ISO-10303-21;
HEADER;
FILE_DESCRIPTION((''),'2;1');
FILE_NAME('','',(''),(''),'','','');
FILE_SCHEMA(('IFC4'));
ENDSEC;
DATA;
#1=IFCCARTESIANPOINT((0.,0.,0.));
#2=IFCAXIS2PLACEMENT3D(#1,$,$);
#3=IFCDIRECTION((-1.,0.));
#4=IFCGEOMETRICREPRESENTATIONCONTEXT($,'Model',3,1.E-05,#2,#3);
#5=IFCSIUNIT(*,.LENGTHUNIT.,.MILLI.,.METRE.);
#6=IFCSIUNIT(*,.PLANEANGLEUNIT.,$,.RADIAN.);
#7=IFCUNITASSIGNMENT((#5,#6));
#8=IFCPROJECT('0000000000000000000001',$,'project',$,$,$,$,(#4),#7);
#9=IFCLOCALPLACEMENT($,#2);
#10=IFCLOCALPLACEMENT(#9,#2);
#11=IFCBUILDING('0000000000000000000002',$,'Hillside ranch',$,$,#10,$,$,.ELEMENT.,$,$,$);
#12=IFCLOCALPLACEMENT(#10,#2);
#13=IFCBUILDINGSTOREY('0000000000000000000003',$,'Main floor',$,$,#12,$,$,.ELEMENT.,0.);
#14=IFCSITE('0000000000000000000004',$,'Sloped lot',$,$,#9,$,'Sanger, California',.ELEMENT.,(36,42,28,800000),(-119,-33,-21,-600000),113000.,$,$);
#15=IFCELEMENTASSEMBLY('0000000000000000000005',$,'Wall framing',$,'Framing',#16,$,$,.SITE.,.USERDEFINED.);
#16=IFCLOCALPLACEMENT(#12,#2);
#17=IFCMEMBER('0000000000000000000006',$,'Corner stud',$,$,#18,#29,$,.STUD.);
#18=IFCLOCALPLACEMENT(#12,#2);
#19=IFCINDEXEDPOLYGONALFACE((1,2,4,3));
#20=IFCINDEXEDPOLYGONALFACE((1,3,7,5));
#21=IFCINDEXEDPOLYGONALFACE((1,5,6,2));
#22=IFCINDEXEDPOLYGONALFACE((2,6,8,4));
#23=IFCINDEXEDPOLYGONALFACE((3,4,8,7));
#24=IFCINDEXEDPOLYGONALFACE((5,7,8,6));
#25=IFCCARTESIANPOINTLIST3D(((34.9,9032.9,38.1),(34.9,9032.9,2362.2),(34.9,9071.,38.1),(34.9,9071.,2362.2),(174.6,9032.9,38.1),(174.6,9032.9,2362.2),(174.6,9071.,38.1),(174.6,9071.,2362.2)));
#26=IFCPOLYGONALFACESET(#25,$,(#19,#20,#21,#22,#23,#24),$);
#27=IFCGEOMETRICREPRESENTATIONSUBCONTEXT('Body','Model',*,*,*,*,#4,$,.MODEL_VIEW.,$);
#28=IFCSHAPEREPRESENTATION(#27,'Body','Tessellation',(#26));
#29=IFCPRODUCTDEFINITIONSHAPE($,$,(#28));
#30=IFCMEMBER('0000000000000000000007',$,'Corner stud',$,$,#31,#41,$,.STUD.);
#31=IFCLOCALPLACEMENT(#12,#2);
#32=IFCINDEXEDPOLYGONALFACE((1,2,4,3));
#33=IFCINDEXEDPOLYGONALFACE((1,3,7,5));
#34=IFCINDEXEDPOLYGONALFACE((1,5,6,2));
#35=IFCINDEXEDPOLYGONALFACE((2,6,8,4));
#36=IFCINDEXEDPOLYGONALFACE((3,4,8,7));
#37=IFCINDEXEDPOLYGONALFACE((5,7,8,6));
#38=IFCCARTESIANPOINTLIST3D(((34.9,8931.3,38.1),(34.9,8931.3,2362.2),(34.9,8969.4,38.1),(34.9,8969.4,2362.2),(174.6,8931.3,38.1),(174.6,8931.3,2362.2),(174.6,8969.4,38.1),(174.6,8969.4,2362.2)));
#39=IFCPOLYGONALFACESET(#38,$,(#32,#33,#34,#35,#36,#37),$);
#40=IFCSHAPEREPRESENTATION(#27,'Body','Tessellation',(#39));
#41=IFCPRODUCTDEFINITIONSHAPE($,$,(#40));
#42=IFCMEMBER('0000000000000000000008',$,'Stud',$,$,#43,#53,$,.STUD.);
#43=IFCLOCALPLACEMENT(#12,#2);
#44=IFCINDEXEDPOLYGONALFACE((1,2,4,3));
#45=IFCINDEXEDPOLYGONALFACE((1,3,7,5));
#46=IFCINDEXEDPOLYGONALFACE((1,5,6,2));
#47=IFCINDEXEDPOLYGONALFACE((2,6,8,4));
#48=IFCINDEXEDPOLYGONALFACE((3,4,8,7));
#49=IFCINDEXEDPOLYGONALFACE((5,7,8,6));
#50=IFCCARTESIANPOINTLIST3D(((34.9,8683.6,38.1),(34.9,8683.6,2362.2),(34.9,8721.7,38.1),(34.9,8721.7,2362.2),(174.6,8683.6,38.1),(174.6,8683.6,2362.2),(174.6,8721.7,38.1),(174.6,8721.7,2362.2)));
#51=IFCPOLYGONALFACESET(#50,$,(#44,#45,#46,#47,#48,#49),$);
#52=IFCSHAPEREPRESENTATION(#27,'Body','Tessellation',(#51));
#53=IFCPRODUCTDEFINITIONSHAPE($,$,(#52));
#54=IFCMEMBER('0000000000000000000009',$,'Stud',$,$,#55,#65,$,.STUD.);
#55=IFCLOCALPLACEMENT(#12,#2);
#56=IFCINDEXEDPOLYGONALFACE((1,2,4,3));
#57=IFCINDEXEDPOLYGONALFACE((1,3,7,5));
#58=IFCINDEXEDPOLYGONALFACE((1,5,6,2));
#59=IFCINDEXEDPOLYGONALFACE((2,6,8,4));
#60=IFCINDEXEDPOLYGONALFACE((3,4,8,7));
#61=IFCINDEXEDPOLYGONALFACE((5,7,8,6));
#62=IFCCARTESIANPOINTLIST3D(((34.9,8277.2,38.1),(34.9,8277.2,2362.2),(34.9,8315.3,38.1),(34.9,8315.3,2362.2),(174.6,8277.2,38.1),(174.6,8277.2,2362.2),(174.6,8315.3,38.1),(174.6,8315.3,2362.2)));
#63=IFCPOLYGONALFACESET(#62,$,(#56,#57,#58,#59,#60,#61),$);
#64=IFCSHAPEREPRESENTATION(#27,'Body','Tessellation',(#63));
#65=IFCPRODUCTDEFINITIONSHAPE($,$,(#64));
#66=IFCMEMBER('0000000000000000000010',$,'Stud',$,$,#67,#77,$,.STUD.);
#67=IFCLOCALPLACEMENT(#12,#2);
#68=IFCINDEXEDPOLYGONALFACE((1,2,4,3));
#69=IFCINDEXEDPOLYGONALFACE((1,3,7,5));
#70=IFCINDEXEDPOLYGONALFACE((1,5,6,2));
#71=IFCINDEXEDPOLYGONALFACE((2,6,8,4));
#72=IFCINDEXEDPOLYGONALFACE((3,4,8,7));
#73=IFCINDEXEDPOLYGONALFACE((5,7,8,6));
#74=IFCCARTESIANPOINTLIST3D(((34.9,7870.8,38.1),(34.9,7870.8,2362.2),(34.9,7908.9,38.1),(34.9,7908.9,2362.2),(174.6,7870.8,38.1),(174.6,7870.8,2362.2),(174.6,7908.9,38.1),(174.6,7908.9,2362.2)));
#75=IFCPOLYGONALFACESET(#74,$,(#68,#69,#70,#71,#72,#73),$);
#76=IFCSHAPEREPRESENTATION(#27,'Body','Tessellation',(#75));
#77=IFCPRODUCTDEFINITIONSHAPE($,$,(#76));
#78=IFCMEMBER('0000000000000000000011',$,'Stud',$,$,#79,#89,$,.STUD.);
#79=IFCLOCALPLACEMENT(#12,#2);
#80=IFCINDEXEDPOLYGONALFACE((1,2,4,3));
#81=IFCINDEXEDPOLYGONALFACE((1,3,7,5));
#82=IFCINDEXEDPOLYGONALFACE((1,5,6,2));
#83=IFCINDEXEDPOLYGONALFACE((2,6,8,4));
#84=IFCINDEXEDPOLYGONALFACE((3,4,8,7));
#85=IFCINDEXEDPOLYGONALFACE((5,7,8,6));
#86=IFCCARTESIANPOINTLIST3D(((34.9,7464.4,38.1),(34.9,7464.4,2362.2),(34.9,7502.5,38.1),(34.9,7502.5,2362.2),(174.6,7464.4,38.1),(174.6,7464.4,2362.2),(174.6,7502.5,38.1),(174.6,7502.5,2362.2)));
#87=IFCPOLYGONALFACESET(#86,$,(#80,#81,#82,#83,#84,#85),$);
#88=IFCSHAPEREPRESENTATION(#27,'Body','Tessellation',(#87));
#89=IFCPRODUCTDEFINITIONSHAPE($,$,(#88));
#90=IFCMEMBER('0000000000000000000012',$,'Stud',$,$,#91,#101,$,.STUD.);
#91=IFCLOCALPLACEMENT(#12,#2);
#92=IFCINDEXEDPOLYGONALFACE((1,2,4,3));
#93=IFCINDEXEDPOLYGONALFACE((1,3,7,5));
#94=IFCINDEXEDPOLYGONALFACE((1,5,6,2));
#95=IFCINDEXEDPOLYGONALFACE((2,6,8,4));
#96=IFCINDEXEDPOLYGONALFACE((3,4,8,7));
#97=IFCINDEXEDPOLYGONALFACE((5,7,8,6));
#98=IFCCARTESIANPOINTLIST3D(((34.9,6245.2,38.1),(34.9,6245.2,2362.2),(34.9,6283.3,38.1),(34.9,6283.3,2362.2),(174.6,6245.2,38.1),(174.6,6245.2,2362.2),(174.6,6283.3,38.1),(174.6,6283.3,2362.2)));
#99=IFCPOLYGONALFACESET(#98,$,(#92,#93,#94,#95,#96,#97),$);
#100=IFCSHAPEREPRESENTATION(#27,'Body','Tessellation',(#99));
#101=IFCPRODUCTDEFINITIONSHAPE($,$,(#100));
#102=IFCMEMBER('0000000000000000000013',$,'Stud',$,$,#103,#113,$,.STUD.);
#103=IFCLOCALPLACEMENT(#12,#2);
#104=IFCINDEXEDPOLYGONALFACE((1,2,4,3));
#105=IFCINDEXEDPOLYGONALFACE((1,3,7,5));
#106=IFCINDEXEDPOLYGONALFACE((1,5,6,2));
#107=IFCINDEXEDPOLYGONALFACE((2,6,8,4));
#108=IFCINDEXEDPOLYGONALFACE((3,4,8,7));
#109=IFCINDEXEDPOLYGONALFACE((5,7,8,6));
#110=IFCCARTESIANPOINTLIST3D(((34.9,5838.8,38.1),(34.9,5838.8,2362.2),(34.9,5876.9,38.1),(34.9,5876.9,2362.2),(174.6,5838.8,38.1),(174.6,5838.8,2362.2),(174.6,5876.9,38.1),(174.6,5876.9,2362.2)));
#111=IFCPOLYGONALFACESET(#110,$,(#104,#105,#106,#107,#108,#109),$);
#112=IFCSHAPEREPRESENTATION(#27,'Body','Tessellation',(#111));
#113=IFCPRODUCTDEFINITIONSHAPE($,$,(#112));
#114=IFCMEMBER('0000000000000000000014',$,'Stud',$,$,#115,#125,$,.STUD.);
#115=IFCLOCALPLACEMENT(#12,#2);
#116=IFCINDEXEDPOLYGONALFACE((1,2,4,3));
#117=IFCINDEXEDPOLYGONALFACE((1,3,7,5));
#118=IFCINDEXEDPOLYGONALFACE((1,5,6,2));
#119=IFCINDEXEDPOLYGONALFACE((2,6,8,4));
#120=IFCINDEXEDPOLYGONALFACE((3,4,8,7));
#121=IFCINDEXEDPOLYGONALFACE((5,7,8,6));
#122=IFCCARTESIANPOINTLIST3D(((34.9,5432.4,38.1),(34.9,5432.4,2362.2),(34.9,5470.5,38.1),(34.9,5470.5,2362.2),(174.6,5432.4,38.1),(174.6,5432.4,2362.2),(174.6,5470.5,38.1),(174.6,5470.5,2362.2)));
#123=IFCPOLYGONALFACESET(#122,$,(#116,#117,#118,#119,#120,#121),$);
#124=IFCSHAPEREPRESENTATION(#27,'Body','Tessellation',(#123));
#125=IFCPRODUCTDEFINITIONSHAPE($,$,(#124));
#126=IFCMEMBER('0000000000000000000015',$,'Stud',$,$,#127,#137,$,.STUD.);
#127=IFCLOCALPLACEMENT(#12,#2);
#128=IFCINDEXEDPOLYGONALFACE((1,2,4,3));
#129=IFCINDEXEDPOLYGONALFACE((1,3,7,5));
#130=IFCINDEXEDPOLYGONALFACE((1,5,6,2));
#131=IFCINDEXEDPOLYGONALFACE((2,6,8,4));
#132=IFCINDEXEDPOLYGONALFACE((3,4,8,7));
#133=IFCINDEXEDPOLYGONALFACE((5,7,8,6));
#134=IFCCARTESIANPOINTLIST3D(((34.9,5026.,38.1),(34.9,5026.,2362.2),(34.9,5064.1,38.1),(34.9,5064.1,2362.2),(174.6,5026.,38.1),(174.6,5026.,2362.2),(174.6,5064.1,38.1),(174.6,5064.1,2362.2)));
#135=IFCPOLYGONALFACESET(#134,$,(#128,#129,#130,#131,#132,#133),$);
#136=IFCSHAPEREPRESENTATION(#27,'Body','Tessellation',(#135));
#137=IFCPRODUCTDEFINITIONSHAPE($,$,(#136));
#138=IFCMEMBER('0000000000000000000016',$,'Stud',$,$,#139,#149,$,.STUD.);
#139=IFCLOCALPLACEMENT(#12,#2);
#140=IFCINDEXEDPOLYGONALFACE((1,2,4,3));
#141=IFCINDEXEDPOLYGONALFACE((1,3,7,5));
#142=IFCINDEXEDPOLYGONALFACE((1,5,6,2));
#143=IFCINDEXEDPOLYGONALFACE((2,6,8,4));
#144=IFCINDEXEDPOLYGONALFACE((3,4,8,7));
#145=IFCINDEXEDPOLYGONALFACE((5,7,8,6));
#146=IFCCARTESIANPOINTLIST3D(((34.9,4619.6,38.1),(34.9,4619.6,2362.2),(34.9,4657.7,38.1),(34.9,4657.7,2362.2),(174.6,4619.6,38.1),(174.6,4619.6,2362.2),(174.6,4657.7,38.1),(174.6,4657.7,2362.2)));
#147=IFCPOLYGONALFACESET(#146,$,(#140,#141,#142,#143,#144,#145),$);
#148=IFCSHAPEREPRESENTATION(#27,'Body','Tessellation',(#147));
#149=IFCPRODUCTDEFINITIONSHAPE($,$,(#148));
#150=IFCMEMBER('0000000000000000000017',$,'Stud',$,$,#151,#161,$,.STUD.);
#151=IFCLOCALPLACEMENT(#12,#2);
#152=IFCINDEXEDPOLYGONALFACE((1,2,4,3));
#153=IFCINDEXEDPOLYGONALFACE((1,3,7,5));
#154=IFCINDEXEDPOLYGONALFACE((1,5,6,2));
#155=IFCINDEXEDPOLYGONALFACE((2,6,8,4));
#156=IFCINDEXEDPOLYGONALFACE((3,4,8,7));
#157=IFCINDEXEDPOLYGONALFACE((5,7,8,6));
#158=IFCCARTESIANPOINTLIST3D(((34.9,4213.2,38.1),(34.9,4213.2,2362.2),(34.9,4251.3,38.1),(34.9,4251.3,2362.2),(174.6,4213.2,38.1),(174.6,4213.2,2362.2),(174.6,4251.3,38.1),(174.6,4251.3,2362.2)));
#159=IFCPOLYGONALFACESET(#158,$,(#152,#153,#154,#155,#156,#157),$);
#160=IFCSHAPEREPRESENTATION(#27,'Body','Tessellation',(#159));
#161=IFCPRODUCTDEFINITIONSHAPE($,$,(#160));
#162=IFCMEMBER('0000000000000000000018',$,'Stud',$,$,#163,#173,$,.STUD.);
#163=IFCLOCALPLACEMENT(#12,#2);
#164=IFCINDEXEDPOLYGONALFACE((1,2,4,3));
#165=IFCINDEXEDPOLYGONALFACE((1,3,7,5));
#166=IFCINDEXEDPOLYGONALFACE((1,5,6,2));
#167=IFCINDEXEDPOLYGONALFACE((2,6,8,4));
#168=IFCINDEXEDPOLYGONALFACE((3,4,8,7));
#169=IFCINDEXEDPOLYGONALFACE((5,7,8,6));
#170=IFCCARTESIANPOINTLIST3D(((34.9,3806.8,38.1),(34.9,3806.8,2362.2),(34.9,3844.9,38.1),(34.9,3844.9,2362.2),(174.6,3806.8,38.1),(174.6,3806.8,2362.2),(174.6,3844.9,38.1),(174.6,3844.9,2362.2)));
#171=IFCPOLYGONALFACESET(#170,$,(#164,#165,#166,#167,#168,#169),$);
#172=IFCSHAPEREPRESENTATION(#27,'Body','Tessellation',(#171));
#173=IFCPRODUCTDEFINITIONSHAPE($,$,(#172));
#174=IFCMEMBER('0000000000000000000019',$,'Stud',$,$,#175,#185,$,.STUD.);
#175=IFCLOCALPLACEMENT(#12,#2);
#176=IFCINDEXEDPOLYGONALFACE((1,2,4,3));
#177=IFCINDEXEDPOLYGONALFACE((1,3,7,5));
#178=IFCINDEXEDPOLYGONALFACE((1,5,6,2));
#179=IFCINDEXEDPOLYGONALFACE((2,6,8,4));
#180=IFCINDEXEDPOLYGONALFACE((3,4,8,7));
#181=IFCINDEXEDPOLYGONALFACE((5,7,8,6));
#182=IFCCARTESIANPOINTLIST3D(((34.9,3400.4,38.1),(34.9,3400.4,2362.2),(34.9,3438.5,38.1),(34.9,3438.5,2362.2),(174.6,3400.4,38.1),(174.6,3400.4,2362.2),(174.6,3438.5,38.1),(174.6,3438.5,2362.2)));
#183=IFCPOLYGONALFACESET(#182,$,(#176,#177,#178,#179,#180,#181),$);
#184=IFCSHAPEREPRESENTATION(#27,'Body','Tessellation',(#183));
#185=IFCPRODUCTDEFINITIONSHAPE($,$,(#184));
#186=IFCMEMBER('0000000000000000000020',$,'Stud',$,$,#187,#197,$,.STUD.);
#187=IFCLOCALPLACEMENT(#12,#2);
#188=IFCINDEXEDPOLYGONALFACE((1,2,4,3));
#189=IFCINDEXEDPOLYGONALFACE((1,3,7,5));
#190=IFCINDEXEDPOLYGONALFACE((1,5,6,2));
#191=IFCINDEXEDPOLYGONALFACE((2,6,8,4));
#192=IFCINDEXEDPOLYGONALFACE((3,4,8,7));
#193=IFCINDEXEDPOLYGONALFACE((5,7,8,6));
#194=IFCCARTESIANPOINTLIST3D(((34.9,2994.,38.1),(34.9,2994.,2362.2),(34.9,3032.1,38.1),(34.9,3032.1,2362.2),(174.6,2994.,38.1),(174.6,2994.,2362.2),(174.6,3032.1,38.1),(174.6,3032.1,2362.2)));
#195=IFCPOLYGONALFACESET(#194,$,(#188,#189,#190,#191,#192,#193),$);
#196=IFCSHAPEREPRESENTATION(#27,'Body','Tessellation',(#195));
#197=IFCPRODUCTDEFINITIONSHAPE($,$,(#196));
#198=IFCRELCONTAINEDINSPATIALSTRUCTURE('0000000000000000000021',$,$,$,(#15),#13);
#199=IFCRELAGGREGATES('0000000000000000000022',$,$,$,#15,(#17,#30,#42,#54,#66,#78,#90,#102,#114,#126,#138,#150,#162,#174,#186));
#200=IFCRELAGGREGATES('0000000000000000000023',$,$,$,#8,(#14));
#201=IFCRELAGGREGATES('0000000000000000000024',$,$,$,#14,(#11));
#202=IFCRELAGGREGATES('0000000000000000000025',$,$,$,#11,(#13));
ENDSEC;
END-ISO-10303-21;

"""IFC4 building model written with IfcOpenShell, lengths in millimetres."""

from ifc_helpers import new_model, si_unit, direction, frame, origin, origin_with_axes, place, context, subcontext, project, spatial, polyline, outline, extrude, element, aggregate, save


model = new_model("IFC4")

# Units and contexts
model_context = context("Model", 3, precision=1e-05, world=origin(), true_north=direction((-1.0, 0.0)))
body_context = subcontext(model_context, "Body", "Model", "MODEL_VIEW")
ifc_project = project(units=[si_unit("LENGTHUNIT", "METRE", prefix="MILLI"), si_unit("PLANEANGLEUNIT", "RADIAN")], contexts=[model_context])

# Site, building, storey
site_placement = place(None, origin())
site = spatial("IfcSite", under=ifc_project, at=site_placement, Name="Sloped lot", LongName="Sanger, California", CompositionType="ELEMENT", RefLatitude=(36, 42, 28, 800000), RefLongitude=(-119, -33, -21, -600000), RefElevation=113000.0)
building_placement = place(site_placement, origin())
building = spatial("IfcBuilding", under=site, at=building_placement, Name="Hillside ranch", CompositionType="ELEMENT")
storey_placement = place(building_placement, origin())
storey = spatial("IfcBuildingStorey", under=building, at=storey_placement, Name="Main floor", CompositionType="ELEMENT", Elevation=0.0)

# Element assembly, members
assembly_placement = place(storey_placement, origin_with_axes())
assembly = element("IfcElementAssembly", 1, at=assembly_placement, inside=storey, Name="Wall framing", ObjectType="Framing", AssemblyPlace="SITE", PredefinedType="USERDEFINED")
member_1_placement = place(storey_placement, origin_with_axes())
member_1 = element("IfcMember", 2, at=member_1_placement, Name="Corner stud", PredefinedType="STUD", context=body_context, shape_type="SweptSolid", body=[
    extrude(outline(polyline([(0.0, 0.0), (38.1, 0.0), (38.1, 139.7), (0.0, 139.7), (0.0, 0.0)])), frame((34.9, 9071.0, 38.1), z_axis=(0.0, 0.0, 1.0), x_axis=(0.0, -1.0, 0.0)), (0.0, 0.0, 1.0), 2324.1),
])
member_2_placement = place(storey_placement, origin_with_axes())
member_2 = element("IfcMember", 3, at=member_2_placement, Name="Corner stud", PredefinedType="STUD", context=body_context, shape_type="SweptSolid", body=[
    extrude(outline(polyline([(0.0, 0.0), (38.1, 0.0), (38.1, 139.7), (0.0, 139.7), (0.0, 0.0)])), frame((34.9, 8969.4, 38.1), z_axis=(0.0, 0.0, 1.0), x_axis=(0.0, -1.0, 0.0)), (0.0, 0.0, 1.0), 2324.1),
])
member_3_placement = place(storey_placement, origin_with_axes())
member_3 = element("IfcMember", 4, at=member_3_placement, Name="Stud", PredefinedType="STUD", context=body_context, shape_type="SweptSolid", body=[
    extrude(outline(polyline([(0.0, 0.0), (38.1, 0.0), (38.1, 139.7), (0.0, 139.7), (0.0, 0.0)])), frame((34.9, 8721.7, 38.1), z_axis=(0.0, 0.0, 1.0), x_axis=(0.0, -1.0, 0.0)), (0.0, 0.0, 1.0), 2324.1),
])
member_4_placement = place(storey_placement, origin_with_axes())
member_4 = element("IfcMember", 5, at=member_4_placement, Name="Stud", PredefinedType="STUD", context=body_context, shape_type="SweptSolid", body=[
    extrude(outline(polyline([(0.0, 0.0), (38.1, 0.0), (38.1, 139.7), (0.0, 139.7), (0.0, 0.0)])), frame((34.9, 8315.3, 38.1), z_axis=(0.0, 0.0, 1.0), x_axis=(0.0, -1.0, 0.0)), (0.0, 0.0, 1.0), 2324.1),
])
member_5_placement = place(storey_placement, origin_with_axes())
member_5 = element("IfcMember", 6, at=member_5_placement, Name="Stud", PredefinedType="STUD", context=body_context, shape_type="SweptSolid", body=[
    extrude(outline(polyline([(0.0, 0.0), (38.1, 0.0), (38.1, 139.7), (0.0, 139.7), (0.0, 0.0)])), frame((34.9, 7908.9, 38.1), z_axis=(0.0, 0.0, 1.0), x_axis=(0.0, -1.0, 0.0)), (0.0, 0.0, 1.0), 2324.1),
])
member_6_placement = place(storey_placement, origin_with_axes())
member_6 = element("IfcMember", 7, at=member_6_placement, Name="Stud", PredefinedType="STUD", context=body_context, shape_type="SweptSolid", body=[
    extrude(outline(polyline([(0.0, 0.0), (38.1, 0.0), (38.1, 139.7), (0.0, 139.7), (0.0, 0.0)])), frame((34.9, 7502.5, 38.1), z_axis=(0.0, 0.0, 1.0), x_axis=(0.0, -1.0, 0.0)), (0.0, 0.0, 1.0), 2324.1),
])
member_7_placement = place(storey_placement, origin_with_axes())
member_7 = element("IfcMember", 8, at=member_7_placement, Name="Stud", PredefinedType="STUD", context=body_context, shape_type="SweptSolid", body=[
    extrude(outline(polyline([(0.0, 0.0), (38.1, 0.0), (38.1, 139.7), (0.0, 139.7), (0.0, 0.0)])), frame((34.9, 6283.3, 38.1), z_axis=(0.0, 0.0, 1.0), x_axis=(0.0, -1.0, 0.0)), (0.0, 0.0, 1.0), 2324.1),
])
member_8_placement = place(storey_placement, origin_with_axes())
member_8 = element("IfcMember", 9, at=member_8_placement, Name="Stud", PredefinedType="STUD", context=body_context, shape_type="SweptSolid", body=[
    extrude(outline(polyline([(0.0, 0.0), (38.1, 0.0), (38.1, 139.7), (0.0, 139.7), (0.0, 0.0)])), frame((34.9, 5876.9, 38.1), z_axis=(0.0, 0.0, 1.0), x_axis=(0.0, -1.0, 0.0)), (0.0, 0.0, 1.0), 2324.1),
])
member_9_placement = place(storey_placement, origin_with_axes())
member_9 = element("IfcMember", 10, at=member_9_placement, Name="Stud", PredefinedType="STUD", context=body_context, shape_type="SweptSolid", body=[
    extrude(outline(polyline([(0.0, 0.0), (38.1, 0.0), (38.1, 139.7), (0.0, 139.7), (0.0, 0.0)])), frame((34.9, 5470.5, 38.1), z_axis=(0.0, 0.0, 1.0), x_axis=(0.0, -1.0, 0.0)), (0.0, 0.0, 1.0), 2324.1),
])
member_10_placement = place(storey_placement, origin_with_axes())
member_10 = element("IfcMember", 11, at=member_10_placement, Name="Stud", PredefinedType="STUD", context=body_context, shape_type="SweptSolid", body=[
    extrude(outline(polyline([(0.0, 0.0), (38.1, 0.0), (38.1, 139.7), (0.0, 139.7), (0.0, 0.0)])), frame((34.9, 5064.1, 38.1), z_axis=(0.0, 0.0, 1.0), x_axis=(0.0, -1.0, 0.0)), (0.0, 0.0, 1.0), 2324.1),
])
member_11_placement = place(storey_placement, origin_with_axes())
member_11 = element("IfcMember", 12, at=member_11_placement, Name="Stud", PredefinedType="STUD", context=body_context, shape_type="SweptSolid", body=[
    extrude(outline(polyline([(0.0, 0.0), (38.1, 0.0), (38.1, 139.7), (0.0, 139.7), (0.0, 0.0)])), frame((34.9, 4657.7, 38.1), z_axis=(0.0, 0.0, 1.0), x_axis=(0.0, -1.0, 0.0)), (0.0, 0.0, 1.0), 2324.1),
])
member_12_placement = place(storey_placement, origin_with_axes())
member_12 = element("IfcMember", 13, at=member_12_placement, Name="Stud", PredefinedType="STUD", context=body_context, shape_type="SweptSolid", body=[
    extrude(outline(polyline([(0.0, 0.0), (38.1, 0.0), (38.1, 139.7), (0.0, 139.7), (0.0, 0.0)])), frame((34.9, 4251.3, 38.1), z_axis=(0.0, 0.0, 1.0), x_axis=(0.0, -1.0, 0.0)), (0.0, 0.0, 1.0), 2324.1),
])
member_13_placement = place(storey_placement, origin_with_axes())
member_13 = element("IfcMember", 14, at=member_13_placement, Name="Stud", PredefinedType="STUD", context=body_context, shape_type="SweptSolid", body=[
    extrude(outline(polyline([(0.0, 0.0), (38.1, 0.0), (38.1, 139.7), (0.0, 139.7), (0.0, 0.0)])), frame((34.9, 3844.9, 38.1), z_axis=(0.0, 0.0, 1.0), x_axis=(0.0, -1.0, 0.0)), (0.0, 0.0, 1.0), 2324.1),
])
member_14_placement = place(storey_placement, origin_with_axes())
member_14 = element("IfcMember", 15, at=member_14_placement, Name="Stud", PredefinedType="STUD", context=body_context, shape_type="SweptSolid", body=[
    extrude(outline(polyline([(0.0, 0.0), (38.1, 0.0), (38.1, 139.7), (0.0, 139.7), (0.0, 0.0)])), frame((34.9, 3438.5, 38.1), z_axis=(0.0, 0.0, 1.0), x_axis=(0.0, -1.0, 0.0)), (0.0, 0.0, 1.0), 2324.1),
])
member_15_placement = place(storey_placement, origin_with_axes())
member_15 = element("IfcMember", 16, at=member_15_placement, Name="Stud", PredefinedType="STUD", context=body_context, shape_type="SweptSolid", body=[
    extrude(outline(polyline([(0.0, 0.0), (38.1, 0.0), (38.1, 139.7), (0.0, 139.7), (0.0, 0.0)])), frame((34.9, 3032.1, 38.1), z_axis=(0.0, 0.0, 1.0), x_axis=(0.0, -1.0, 0.0)), (0.0, 0.0, 1.0), 2324.1),
])
aggregate(assembly, [member_1, member_2, member_3, member_4, member_5, member_6, member_7, member_8, member_9, member_10, member_11, member_12, member_13, member_14, member_15])

save(model, "model.ifc")
